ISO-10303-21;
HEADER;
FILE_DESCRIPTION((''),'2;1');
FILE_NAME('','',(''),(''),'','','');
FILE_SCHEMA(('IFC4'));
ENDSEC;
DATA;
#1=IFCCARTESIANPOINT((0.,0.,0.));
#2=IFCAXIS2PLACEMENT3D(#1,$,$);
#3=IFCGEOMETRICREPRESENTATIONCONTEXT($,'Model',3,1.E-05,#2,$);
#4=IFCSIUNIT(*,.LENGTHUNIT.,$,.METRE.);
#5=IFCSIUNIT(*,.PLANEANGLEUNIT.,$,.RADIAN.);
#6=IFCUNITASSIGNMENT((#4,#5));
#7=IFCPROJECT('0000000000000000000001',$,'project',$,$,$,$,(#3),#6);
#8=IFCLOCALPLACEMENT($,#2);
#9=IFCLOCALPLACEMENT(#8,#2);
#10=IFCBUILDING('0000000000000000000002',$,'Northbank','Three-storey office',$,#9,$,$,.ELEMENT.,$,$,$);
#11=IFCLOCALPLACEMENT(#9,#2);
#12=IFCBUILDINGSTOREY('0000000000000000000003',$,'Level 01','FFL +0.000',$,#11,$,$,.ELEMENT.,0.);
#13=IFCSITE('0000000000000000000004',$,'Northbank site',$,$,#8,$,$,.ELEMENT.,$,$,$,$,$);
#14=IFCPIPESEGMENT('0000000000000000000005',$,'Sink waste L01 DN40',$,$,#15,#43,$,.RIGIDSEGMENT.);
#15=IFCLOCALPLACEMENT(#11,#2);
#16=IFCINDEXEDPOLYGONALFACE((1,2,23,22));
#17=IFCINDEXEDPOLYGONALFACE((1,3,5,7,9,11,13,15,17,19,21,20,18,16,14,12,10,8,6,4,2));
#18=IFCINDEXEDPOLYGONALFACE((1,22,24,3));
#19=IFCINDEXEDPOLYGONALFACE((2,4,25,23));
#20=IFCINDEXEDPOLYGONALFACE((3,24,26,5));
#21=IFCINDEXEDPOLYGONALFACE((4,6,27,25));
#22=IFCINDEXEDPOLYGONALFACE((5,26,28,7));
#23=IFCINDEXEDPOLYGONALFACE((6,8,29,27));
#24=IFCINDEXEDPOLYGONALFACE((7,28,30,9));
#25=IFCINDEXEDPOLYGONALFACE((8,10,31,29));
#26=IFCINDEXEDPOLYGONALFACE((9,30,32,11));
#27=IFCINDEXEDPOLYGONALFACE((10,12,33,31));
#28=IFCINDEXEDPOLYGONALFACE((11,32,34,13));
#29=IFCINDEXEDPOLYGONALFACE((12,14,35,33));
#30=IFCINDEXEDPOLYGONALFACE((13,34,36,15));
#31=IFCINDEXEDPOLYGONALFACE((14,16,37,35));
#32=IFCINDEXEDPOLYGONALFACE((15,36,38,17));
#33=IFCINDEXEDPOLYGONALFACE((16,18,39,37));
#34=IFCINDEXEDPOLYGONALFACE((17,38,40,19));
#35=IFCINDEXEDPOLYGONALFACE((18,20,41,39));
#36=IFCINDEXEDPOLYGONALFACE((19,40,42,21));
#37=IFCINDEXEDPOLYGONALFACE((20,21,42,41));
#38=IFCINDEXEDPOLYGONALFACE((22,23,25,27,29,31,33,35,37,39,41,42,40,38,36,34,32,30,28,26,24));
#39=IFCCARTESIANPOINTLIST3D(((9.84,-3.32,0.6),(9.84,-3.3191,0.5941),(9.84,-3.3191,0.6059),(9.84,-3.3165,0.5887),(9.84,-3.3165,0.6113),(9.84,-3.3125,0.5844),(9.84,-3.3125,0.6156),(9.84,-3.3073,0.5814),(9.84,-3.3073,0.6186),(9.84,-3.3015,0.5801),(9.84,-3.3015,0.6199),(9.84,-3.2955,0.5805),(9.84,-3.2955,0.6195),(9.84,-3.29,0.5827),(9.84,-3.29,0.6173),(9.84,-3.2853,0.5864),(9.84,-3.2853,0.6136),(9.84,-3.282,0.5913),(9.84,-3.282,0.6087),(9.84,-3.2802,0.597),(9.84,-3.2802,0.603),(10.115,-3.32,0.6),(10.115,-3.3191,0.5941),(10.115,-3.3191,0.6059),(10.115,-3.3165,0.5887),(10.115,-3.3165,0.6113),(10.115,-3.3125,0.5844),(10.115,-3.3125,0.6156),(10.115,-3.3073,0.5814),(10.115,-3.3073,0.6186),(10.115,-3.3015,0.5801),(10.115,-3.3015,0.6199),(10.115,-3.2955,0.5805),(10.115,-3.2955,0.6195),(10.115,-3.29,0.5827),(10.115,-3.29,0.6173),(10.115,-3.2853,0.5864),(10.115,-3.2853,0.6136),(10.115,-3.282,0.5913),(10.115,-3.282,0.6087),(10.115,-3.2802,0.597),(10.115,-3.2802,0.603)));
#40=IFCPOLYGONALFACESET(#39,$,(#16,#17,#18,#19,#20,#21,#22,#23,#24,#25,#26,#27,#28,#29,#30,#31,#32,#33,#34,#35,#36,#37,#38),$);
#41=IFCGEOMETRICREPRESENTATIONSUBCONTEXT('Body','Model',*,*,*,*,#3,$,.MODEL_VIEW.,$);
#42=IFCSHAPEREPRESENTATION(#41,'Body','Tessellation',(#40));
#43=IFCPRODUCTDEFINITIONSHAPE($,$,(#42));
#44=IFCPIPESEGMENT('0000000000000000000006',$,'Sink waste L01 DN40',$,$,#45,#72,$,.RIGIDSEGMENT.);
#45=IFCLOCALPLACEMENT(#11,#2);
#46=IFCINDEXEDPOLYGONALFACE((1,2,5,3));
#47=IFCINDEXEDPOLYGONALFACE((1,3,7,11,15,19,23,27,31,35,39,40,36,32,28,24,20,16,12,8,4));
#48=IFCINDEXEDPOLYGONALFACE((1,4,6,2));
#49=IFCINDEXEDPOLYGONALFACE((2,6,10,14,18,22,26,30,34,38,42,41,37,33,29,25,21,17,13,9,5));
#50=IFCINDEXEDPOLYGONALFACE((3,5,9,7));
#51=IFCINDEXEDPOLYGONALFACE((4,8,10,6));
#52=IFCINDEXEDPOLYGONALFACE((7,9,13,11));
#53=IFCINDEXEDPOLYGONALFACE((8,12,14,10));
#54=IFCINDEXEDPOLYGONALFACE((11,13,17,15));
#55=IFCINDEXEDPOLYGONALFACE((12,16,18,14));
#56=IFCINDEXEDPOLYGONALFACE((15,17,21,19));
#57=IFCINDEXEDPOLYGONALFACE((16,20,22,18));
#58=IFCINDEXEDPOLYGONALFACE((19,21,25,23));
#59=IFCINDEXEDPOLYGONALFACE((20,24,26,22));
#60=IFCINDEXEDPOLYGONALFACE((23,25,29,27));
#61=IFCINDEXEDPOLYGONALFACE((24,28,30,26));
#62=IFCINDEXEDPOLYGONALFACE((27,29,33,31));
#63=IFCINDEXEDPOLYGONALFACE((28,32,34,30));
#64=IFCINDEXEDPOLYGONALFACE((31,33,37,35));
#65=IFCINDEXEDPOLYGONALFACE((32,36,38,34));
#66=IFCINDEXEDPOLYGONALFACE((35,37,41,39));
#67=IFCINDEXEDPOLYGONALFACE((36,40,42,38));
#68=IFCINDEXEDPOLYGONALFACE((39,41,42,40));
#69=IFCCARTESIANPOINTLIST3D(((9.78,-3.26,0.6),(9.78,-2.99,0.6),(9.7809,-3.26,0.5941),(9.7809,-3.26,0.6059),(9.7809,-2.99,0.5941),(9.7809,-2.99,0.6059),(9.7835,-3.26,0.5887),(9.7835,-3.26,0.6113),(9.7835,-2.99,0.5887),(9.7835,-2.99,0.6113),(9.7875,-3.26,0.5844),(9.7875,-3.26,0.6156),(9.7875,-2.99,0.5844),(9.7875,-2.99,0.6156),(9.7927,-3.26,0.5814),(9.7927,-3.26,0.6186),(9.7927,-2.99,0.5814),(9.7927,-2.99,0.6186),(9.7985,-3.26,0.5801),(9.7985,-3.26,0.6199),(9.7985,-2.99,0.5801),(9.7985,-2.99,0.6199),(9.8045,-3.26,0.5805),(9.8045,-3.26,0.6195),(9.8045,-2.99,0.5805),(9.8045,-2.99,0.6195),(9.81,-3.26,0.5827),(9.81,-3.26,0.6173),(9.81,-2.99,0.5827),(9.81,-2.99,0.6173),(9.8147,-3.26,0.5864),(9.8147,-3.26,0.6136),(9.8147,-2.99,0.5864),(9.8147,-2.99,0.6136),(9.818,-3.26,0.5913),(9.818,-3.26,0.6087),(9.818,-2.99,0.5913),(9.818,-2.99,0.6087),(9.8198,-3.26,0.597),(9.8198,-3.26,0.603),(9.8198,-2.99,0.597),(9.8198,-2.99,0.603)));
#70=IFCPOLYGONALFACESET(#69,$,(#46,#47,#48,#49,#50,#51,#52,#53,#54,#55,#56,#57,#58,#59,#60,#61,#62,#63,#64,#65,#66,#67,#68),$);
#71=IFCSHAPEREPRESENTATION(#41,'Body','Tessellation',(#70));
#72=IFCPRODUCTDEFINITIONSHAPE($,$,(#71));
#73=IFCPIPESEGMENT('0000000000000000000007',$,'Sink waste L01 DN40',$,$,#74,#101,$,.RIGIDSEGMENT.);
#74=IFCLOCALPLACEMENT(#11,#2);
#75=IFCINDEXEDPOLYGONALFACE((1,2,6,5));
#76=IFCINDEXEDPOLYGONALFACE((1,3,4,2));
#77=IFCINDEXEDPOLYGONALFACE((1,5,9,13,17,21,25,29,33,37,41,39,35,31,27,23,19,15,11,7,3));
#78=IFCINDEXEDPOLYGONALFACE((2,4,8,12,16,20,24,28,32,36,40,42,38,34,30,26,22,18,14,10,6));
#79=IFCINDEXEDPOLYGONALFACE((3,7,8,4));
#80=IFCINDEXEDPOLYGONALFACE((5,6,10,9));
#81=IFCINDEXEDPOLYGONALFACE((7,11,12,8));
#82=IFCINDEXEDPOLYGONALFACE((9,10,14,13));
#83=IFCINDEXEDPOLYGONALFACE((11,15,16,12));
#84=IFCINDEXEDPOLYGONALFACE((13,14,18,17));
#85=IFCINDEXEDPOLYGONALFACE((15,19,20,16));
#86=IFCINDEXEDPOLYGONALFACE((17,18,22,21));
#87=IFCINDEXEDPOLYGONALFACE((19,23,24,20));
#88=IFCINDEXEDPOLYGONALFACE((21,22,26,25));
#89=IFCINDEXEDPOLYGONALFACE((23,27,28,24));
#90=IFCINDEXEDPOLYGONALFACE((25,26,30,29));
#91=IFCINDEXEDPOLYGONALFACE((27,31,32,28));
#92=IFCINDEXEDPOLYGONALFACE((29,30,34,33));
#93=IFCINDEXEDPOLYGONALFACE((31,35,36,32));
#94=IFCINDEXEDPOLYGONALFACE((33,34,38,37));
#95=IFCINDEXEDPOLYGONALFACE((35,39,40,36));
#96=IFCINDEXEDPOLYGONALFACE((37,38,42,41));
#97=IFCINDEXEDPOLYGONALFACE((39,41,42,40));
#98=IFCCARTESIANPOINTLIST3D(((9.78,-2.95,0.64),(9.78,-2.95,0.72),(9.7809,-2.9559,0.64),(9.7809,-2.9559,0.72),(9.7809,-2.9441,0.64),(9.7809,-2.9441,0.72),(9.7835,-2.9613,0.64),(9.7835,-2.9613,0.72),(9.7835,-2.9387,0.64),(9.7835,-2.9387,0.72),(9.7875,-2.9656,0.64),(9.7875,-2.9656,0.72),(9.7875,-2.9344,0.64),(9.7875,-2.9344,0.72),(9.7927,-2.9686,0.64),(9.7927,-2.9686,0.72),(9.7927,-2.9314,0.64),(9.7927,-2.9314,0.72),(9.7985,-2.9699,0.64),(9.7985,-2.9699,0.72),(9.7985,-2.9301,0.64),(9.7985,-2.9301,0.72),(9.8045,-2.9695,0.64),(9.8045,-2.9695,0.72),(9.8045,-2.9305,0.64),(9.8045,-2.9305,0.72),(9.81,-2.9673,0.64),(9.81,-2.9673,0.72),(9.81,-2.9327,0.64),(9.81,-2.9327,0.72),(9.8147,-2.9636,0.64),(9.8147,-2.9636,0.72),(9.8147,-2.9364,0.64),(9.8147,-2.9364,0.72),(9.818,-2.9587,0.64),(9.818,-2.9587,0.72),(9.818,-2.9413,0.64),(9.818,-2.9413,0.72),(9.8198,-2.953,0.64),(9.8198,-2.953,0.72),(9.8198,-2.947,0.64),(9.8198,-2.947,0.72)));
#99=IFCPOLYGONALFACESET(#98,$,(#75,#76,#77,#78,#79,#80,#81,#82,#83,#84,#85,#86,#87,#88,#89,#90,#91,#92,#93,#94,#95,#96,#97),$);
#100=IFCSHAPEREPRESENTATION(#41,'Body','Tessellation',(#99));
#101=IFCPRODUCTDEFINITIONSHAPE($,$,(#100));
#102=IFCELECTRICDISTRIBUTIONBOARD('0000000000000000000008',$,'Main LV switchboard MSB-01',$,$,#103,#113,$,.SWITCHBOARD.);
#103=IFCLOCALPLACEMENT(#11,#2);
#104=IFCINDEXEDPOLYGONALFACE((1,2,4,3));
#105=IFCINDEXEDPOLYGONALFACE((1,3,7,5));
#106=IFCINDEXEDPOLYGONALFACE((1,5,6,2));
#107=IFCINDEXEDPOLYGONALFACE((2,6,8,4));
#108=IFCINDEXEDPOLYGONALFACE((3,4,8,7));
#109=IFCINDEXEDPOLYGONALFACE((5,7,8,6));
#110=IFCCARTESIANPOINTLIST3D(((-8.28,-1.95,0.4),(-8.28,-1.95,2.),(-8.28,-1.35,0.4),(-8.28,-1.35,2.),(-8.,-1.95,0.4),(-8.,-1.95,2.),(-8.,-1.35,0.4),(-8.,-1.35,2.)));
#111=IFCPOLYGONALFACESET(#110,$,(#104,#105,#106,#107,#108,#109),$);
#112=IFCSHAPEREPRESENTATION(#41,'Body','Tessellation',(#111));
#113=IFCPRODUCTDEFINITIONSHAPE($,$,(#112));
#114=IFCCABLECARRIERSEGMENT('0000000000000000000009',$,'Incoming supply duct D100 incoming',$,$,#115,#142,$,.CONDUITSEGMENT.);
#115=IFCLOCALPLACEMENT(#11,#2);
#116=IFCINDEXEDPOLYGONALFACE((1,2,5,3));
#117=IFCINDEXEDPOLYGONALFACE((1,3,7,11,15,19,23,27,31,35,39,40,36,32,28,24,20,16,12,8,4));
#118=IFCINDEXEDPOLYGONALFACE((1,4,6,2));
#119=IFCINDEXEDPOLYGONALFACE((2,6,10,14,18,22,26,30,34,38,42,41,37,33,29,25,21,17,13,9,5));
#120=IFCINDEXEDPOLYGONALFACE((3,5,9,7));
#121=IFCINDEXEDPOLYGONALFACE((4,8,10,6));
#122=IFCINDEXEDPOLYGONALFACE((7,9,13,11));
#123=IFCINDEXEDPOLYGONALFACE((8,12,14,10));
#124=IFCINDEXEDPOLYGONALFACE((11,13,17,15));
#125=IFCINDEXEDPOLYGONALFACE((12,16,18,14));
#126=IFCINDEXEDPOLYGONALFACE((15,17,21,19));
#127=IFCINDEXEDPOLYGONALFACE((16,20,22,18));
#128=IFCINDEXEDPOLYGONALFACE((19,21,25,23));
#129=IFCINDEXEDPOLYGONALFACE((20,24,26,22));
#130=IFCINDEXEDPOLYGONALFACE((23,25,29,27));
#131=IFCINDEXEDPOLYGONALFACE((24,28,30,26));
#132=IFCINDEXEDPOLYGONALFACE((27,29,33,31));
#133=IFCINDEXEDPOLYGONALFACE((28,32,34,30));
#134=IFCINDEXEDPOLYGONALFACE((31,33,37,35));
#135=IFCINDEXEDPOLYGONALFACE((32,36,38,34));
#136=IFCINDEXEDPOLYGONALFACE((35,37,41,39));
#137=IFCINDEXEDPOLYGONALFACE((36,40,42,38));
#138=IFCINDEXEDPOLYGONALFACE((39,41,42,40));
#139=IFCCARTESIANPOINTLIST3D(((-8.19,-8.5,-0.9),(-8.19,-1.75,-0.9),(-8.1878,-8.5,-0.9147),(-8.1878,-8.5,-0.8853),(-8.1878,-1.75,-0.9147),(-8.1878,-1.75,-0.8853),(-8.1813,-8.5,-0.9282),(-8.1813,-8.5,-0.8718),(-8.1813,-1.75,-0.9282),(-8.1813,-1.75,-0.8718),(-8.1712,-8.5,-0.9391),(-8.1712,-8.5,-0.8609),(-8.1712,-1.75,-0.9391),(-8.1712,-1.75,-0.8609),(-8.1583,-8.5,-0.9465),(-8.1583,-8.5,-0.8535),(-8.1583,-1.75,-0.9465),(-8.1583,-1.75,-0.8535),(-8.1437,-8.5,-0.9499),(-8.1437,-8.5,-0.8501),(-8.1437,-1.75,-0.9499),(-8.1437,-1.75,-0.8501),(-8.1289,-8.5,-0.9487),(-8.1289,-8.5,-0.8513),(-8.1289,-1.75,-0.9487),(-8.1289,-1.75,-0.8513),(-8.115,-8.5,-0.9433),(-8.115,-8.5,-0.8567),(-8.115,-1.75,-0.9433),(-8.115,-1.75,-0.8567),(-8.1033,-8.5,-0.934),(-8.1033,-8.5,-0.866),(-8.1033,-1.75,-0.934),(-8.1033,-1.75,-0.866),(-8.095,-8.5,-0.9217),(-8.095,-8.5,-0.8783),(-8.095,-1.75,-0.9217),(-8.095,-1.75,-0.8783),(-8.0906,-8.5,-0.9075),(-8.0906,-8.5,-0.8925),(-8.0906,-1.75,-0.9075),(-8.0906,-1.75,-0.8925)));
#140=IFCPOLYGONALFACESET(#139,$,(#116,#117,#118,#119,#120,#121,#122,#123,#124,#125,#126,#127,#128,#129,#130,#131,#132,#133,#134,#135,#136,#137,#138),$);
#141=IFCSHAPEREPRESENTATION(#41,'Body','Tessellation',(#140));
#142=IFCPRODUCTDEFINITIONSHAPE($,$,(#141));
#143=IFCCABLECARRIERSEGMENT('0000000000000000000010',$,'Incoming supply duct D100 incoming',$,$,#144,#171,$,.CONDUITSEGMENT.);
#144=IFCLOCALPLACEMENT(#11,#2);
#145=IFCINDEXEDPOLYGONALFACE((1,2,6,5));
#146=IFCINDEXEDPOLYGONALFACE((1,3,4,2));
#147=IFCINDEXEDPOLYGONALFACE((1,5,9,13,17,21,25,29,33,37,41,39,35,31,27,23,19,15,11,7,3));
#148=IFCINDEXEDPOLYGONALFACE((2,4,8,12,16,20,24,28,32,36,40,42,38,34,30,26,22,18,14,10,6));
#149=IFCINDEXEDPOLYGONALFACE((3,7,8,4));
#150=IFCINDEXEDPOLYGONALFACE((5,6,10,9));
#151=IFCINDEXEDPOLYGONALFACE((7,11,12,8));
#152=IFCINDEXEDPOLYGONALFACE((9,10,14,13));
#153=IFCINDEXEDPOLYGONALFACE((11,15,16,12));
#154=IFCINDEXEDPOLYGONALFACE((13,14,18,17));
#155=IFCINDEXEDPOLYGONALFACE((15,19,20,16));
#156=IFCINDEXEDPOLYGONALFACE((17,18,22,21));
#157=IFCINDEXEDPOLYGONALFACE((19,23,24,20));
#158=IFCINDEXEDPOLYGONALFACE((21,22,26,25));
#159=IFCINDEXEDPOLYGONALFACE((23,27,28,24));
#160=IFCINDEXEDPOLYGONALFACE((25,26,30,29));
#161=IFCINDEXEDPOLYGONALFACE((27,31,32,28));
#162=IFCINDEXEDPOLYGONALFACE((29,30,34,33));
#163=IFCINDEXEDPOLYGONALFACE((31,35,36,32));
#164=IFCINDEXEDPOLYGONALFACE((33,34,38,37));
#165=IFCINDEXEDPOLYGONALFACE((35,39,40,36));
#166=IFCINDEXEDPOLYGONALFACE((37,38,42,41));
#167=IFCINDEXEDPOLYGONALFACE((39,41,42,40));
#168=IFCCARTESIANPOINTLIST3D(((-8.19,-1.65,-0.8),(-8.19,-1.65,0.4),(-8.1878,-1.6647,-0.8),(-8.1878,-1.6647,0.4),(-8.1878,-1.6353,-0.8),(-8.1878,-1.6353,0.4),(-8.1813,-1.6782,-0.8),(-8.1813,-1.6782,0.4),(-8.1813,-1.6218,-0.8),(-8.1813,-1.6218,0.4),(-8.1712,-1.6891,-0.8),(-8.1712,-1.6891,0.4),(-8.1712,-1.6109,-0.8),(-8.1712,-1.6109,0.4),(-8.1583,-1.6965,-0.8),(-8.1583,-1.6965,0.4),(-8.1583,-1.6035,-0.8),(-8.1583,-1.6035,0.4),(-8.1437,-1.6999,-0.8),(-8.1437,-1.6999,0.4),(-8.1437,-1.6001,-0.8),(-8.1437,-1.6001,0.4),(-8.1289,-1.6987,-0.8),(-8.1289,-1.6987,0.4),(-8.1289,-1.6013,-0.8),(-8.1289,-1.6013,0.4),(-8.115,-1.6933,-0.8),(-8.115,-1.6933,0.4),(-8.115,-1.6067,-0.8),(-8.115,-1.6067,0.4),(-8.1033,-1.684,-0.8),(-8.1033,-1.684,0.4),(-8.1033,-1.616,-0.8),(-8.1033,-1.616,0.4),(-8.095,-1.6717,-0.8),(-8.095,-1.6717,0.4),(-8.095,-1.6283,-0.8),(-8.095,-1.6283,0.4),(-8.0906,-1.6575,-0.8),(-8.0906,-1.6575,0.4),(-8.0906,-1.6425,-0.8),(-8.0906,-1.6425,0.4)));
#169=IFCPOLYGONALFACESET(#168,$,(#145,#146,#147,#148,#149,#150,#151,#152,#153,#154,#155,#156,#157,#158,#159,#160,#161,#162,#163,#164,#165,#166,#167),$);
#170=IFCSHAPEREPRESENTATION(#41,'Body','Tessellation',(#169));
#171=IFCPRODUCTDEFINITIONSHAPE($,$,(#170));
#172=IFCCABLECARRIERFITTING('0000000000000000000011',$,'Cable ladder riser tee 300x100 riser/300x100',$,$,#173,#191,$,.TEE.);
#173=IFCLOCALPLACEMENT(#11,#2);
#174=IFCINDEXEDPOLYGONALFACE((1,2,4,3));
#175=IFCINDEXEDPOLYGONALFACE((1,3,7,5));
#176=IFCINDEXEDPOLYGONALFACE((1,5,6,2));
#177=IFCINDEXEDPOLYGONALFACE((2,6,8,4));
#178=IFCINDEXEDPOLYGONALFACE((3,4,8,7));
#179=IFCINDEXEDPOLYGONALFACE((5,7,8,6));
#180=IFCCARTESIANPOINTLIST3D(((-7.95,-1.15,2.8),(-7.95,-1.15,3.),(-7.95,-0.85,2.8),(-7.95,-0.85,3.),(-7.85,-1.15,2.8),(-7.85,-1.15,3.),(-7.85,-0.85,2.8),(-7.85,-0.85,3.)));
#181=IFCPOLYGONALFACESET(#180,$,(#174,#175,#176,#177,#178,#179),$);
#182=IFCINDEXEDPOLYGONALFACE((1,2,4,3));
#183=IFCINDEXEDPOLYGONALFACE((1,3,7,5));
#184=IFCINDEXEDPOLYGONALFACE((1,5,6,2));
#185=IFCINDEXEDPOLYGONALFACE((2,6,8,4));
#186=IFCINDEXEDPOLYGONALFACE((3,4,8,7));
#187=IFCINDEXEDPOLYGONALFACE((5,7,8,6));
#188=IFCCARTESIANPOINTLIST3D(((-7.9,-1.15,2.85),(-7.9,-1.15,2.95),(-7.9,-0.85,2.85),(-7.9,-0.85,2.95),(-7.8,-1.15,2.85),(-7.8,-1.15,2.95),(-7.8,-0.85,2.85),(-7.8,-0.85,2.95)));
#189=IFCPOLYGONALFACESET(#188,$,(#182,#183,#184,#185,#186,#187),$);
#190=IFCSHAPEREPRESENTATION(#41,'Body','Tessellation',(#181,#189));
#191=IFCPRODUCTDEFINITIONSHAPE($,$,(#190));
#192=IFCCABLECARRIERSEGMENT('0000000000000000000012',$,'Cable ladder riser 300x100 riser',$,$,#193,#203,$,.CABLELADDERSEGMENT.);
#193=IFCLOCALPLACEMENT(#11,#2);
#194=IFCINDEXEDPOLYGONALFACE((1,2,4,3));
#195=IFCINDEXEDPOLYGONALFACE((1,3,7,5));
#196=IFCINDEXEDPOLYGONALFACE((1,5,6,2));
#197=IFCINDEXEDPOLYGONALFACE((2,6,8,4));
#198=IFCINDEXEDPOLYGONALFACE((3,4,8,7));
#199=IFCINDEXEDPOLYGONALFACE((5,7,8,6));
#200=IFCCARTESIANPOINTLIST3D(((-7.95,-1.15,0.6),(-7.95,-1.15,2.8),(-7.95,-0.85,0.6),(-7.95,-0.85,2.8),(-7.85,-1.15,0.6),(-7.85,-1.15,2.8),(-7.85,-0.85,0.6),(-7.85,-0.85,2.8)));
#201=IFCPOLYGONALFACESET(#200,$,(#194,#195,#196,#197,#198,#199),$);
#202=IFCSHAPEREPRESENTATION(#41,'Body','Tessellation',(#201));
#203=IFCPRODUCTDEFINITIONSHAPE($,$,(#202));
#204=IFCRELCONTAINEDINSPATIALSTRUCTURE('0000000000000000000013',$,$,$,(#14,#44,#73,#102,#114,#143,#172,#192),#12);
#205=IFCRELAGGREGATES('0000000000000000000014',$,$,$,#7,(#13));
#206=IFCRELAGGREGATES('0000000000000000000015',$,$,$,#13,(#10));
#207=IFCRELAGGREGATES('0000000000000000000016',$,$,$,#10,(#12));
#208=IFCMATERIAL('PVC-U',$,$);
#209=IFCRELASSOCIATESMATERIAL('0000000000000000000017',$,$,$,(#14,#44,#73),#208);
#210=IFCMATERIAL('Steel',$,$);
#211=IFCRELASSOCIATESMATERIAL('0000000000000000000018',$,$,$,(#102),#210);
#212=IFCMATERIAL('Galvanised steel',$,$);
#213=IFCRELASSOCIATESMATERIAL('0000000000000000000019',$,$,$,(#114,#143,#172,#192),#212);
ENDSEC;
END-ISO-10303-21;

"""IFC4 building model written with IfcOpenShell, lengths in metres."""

from ifc_helpers import new_model, si_unit, frame, origin, place, context, subcontext, project, spatial, rectangle, circle, extrude, material, element, save


model = new_model("IFC4")

# Units and contexts
model_context = context("Model", 3, precision=1e-05, world=origin())
body_context = subcontext(model_context, "Body", "Model", "MODEL_VIEW")
ifc_project = project(units=[si_unit("LENGTHUNIT", "METRE"), si_unit("PLANEANGLEUNIT", "RADIAN")], contexts=[model_context])

# Site, building, storey
site_placement = place(None, origin())
site = spatial("IfcSite", under=ifc_project, at=site_placement, Name="Northbank site", CompositionType="ELEMENT")
building_placement = place(site_placement, origin())
building = spatial("IfcBuilding", under=site, at=building_placement, Name="Northbank", Description="Three-storey office", CompositionType="ELEMENT")
storey_placement = place(building_placement, origin())
storey = spatial("IfcBuildingStorey", under=building, at=storey_placement, Name="Level 01", Description="FFL +0.000", CompositionType="ELEMENT", Elevation=0.0)

# Shared definitions
ifc_material_1 = material(Name="PVC-U")

# Pipe segments
pipe_segment_1_placement = place(storey_placement, origin())
element("IfcPipeSegment", 1, at=pipe_segment_1_placement, inside=storey, material=ifc_material_1, Name="Sink waste L01 DN40", PredefinedType="RIGIDSEGMENT", context=body_context, shape_type="SweptSolid", body=[
    extrude(circle(Radius=0.02), frame((10.115, -3.3, 0.6), z_axis=(-1.0, 0.0, 0.0), x_axis=(0.0, -1.0, 0.0)), (0.0, 0.0, 1.0), 0.275),
])
pipe_segment_2_placement = place(storey_placement, origin())
element("IfcPipeSegment", 2, at=pipe_segment_2_placement, inside=storey, material=ifc_material_1, Name="Sink waste L01 DN40", PredefinedType="RIGIDSEGMENT", context=body_context, shape_type="SweptSolid", body=[
    extrude(circle(Radius=0.02), frame((9.8, -3.26, 0.6), z_axis=(0.0, 1.0, 0.0), x_axis=(-1.0, 0.0, 0.0)), (0.0, 0.0, 1.0), 0.27),
])
pipe_segment_3_placement = place(storey_placement, origin())
element("IfcPipeSegment", 3, at=pipe_segment_3_placement, inside=storey, material=ifc_material_1, Name="Sink waste L01 DN40", PredefinedType="RIGIDSEGMENT", context=body_context, shape_type="SweptSolid", body=[
    extrude(circle(Radius=0.02), frame((9.8, -2.95, 0.64), z_axis=(0.0, 0.0, 1.0), x_axis=(-1.0, 0.0, 0.0)), (0.0, 0.0, 1.0), 0.08),
])

# Electric distribution board
ifc_material_2 = material(Name="Steel")
electric_distribution_board_placement = place(storey_placement, origin())
element("IfcElectricDistributionBoard", 4, at=electric_distribution_board_placement, inside=storey, material=ifc_material_2, Name="Main LV switchboard MSB-01", PredefinedType="SWITCHBOARD", context=body_context, shape_type="SweptSolid", body=[
    extrude(rectangle(XDim=0.28, YDim=0.6), frame((-8.14, -1.65, 0.4)), (0.0, 0.0, 1.0), 1.6),
])

# Cable carrier segments
ifc_material_3 = material(Name="Galvanised steel")
cable_carrier_segment_1_placement = place(storey_placement, origin())
element("IfcCableCarrierSegment", 5, at=cable_carrier_segment_1_placement, inside=storey, material=ifc_material_3, Name="Incoming supply duct D100 incoming", PredefinedType="CONDUITSEGMENT", context=body_context, shape_type="SweptSolid", body=[
    extrude(circle(Radius=0.05), frame((-8.14, -8.5, -0.9), z_axis=(0.0, 1.0, 0.0), x_axis=(-1.0, 0.0, 0.0)), (0.0, 0.0, 1.0), 6.75),
])
cable_carrier_segment_2_placement = place(storey_placement, origin())
element("IfcCableCarrierSegment", 6, at=cable_carrier_segment_2_placement, inside=storey, material=ifc_material_3, Name="Incoming supply duct D100 incoming", PredefinedType="CONDUITSEGMENT", context=body_context, shape_type="SweptSolid", body=[
    extrude(circle(Radius=0.05), frame((-8.14, -1.65, -0.8), z_axis=(0.0, 0.0, 1.0), x_axis=(-1.0, 0.0, 0.0)), (0.0, 0.0, 1.0), 1.2),
])

# Cable carrier fitting
cable_carrier_fitting_placement = place(storey_placement, origin())
element("IfcCableCarrierFitting", 7, at=cable_carrier_fitting_placement, inside=storey, material=ifc_material_3, Name="Cable ladder riser tee 300x100 riser/300x100", PredefinedType="TEE", context=body_context, shape_type="SweptSolid", body=[
    extrude(rectangle(XDim=0.1, YDim=0.3), frame((-7.9, -1.0, 2.8), z_axis=(0.0, 0.0, 1.0), x_axis=(1.0, 0.0, 0.0)), (0.0, 0.0, 1.0), 0.2),
    extrude(rectangle(XDim=0.3, YDim=0.1), frame((-7.9, -1.0, 2.9), z_axis=(1.0, 0.0, 0.0), x_axis=(0.0, 1.0, 0.0)), (0.0, 0.0, 1.0), 0.1),
])

# Cable carrier segment
cable_carrier_segment_3_placement = place(storey_placement, origin())
element("IfcCableCarrierSegment", 8, at=cable_carrier_segment_3_placement, inside=storey, material=ifc_material_3, Name="Cable ladder riser 300x100 riser", PredefinedType="CABLELADDERSEGMENT", context=body_context, shape_type="SweptSolid", body=[
    extrude(rectangle(XDim=0.1, YDim=0.3), frame((-7.9, -1.0, 0.6), z_axis=(0.0, 0.0, 1.0), x_axis=(1.0, 0.0, 0.0)), (0.0, 0.0, 1.0), 2.2),
])

save(model, "model.ifc")
